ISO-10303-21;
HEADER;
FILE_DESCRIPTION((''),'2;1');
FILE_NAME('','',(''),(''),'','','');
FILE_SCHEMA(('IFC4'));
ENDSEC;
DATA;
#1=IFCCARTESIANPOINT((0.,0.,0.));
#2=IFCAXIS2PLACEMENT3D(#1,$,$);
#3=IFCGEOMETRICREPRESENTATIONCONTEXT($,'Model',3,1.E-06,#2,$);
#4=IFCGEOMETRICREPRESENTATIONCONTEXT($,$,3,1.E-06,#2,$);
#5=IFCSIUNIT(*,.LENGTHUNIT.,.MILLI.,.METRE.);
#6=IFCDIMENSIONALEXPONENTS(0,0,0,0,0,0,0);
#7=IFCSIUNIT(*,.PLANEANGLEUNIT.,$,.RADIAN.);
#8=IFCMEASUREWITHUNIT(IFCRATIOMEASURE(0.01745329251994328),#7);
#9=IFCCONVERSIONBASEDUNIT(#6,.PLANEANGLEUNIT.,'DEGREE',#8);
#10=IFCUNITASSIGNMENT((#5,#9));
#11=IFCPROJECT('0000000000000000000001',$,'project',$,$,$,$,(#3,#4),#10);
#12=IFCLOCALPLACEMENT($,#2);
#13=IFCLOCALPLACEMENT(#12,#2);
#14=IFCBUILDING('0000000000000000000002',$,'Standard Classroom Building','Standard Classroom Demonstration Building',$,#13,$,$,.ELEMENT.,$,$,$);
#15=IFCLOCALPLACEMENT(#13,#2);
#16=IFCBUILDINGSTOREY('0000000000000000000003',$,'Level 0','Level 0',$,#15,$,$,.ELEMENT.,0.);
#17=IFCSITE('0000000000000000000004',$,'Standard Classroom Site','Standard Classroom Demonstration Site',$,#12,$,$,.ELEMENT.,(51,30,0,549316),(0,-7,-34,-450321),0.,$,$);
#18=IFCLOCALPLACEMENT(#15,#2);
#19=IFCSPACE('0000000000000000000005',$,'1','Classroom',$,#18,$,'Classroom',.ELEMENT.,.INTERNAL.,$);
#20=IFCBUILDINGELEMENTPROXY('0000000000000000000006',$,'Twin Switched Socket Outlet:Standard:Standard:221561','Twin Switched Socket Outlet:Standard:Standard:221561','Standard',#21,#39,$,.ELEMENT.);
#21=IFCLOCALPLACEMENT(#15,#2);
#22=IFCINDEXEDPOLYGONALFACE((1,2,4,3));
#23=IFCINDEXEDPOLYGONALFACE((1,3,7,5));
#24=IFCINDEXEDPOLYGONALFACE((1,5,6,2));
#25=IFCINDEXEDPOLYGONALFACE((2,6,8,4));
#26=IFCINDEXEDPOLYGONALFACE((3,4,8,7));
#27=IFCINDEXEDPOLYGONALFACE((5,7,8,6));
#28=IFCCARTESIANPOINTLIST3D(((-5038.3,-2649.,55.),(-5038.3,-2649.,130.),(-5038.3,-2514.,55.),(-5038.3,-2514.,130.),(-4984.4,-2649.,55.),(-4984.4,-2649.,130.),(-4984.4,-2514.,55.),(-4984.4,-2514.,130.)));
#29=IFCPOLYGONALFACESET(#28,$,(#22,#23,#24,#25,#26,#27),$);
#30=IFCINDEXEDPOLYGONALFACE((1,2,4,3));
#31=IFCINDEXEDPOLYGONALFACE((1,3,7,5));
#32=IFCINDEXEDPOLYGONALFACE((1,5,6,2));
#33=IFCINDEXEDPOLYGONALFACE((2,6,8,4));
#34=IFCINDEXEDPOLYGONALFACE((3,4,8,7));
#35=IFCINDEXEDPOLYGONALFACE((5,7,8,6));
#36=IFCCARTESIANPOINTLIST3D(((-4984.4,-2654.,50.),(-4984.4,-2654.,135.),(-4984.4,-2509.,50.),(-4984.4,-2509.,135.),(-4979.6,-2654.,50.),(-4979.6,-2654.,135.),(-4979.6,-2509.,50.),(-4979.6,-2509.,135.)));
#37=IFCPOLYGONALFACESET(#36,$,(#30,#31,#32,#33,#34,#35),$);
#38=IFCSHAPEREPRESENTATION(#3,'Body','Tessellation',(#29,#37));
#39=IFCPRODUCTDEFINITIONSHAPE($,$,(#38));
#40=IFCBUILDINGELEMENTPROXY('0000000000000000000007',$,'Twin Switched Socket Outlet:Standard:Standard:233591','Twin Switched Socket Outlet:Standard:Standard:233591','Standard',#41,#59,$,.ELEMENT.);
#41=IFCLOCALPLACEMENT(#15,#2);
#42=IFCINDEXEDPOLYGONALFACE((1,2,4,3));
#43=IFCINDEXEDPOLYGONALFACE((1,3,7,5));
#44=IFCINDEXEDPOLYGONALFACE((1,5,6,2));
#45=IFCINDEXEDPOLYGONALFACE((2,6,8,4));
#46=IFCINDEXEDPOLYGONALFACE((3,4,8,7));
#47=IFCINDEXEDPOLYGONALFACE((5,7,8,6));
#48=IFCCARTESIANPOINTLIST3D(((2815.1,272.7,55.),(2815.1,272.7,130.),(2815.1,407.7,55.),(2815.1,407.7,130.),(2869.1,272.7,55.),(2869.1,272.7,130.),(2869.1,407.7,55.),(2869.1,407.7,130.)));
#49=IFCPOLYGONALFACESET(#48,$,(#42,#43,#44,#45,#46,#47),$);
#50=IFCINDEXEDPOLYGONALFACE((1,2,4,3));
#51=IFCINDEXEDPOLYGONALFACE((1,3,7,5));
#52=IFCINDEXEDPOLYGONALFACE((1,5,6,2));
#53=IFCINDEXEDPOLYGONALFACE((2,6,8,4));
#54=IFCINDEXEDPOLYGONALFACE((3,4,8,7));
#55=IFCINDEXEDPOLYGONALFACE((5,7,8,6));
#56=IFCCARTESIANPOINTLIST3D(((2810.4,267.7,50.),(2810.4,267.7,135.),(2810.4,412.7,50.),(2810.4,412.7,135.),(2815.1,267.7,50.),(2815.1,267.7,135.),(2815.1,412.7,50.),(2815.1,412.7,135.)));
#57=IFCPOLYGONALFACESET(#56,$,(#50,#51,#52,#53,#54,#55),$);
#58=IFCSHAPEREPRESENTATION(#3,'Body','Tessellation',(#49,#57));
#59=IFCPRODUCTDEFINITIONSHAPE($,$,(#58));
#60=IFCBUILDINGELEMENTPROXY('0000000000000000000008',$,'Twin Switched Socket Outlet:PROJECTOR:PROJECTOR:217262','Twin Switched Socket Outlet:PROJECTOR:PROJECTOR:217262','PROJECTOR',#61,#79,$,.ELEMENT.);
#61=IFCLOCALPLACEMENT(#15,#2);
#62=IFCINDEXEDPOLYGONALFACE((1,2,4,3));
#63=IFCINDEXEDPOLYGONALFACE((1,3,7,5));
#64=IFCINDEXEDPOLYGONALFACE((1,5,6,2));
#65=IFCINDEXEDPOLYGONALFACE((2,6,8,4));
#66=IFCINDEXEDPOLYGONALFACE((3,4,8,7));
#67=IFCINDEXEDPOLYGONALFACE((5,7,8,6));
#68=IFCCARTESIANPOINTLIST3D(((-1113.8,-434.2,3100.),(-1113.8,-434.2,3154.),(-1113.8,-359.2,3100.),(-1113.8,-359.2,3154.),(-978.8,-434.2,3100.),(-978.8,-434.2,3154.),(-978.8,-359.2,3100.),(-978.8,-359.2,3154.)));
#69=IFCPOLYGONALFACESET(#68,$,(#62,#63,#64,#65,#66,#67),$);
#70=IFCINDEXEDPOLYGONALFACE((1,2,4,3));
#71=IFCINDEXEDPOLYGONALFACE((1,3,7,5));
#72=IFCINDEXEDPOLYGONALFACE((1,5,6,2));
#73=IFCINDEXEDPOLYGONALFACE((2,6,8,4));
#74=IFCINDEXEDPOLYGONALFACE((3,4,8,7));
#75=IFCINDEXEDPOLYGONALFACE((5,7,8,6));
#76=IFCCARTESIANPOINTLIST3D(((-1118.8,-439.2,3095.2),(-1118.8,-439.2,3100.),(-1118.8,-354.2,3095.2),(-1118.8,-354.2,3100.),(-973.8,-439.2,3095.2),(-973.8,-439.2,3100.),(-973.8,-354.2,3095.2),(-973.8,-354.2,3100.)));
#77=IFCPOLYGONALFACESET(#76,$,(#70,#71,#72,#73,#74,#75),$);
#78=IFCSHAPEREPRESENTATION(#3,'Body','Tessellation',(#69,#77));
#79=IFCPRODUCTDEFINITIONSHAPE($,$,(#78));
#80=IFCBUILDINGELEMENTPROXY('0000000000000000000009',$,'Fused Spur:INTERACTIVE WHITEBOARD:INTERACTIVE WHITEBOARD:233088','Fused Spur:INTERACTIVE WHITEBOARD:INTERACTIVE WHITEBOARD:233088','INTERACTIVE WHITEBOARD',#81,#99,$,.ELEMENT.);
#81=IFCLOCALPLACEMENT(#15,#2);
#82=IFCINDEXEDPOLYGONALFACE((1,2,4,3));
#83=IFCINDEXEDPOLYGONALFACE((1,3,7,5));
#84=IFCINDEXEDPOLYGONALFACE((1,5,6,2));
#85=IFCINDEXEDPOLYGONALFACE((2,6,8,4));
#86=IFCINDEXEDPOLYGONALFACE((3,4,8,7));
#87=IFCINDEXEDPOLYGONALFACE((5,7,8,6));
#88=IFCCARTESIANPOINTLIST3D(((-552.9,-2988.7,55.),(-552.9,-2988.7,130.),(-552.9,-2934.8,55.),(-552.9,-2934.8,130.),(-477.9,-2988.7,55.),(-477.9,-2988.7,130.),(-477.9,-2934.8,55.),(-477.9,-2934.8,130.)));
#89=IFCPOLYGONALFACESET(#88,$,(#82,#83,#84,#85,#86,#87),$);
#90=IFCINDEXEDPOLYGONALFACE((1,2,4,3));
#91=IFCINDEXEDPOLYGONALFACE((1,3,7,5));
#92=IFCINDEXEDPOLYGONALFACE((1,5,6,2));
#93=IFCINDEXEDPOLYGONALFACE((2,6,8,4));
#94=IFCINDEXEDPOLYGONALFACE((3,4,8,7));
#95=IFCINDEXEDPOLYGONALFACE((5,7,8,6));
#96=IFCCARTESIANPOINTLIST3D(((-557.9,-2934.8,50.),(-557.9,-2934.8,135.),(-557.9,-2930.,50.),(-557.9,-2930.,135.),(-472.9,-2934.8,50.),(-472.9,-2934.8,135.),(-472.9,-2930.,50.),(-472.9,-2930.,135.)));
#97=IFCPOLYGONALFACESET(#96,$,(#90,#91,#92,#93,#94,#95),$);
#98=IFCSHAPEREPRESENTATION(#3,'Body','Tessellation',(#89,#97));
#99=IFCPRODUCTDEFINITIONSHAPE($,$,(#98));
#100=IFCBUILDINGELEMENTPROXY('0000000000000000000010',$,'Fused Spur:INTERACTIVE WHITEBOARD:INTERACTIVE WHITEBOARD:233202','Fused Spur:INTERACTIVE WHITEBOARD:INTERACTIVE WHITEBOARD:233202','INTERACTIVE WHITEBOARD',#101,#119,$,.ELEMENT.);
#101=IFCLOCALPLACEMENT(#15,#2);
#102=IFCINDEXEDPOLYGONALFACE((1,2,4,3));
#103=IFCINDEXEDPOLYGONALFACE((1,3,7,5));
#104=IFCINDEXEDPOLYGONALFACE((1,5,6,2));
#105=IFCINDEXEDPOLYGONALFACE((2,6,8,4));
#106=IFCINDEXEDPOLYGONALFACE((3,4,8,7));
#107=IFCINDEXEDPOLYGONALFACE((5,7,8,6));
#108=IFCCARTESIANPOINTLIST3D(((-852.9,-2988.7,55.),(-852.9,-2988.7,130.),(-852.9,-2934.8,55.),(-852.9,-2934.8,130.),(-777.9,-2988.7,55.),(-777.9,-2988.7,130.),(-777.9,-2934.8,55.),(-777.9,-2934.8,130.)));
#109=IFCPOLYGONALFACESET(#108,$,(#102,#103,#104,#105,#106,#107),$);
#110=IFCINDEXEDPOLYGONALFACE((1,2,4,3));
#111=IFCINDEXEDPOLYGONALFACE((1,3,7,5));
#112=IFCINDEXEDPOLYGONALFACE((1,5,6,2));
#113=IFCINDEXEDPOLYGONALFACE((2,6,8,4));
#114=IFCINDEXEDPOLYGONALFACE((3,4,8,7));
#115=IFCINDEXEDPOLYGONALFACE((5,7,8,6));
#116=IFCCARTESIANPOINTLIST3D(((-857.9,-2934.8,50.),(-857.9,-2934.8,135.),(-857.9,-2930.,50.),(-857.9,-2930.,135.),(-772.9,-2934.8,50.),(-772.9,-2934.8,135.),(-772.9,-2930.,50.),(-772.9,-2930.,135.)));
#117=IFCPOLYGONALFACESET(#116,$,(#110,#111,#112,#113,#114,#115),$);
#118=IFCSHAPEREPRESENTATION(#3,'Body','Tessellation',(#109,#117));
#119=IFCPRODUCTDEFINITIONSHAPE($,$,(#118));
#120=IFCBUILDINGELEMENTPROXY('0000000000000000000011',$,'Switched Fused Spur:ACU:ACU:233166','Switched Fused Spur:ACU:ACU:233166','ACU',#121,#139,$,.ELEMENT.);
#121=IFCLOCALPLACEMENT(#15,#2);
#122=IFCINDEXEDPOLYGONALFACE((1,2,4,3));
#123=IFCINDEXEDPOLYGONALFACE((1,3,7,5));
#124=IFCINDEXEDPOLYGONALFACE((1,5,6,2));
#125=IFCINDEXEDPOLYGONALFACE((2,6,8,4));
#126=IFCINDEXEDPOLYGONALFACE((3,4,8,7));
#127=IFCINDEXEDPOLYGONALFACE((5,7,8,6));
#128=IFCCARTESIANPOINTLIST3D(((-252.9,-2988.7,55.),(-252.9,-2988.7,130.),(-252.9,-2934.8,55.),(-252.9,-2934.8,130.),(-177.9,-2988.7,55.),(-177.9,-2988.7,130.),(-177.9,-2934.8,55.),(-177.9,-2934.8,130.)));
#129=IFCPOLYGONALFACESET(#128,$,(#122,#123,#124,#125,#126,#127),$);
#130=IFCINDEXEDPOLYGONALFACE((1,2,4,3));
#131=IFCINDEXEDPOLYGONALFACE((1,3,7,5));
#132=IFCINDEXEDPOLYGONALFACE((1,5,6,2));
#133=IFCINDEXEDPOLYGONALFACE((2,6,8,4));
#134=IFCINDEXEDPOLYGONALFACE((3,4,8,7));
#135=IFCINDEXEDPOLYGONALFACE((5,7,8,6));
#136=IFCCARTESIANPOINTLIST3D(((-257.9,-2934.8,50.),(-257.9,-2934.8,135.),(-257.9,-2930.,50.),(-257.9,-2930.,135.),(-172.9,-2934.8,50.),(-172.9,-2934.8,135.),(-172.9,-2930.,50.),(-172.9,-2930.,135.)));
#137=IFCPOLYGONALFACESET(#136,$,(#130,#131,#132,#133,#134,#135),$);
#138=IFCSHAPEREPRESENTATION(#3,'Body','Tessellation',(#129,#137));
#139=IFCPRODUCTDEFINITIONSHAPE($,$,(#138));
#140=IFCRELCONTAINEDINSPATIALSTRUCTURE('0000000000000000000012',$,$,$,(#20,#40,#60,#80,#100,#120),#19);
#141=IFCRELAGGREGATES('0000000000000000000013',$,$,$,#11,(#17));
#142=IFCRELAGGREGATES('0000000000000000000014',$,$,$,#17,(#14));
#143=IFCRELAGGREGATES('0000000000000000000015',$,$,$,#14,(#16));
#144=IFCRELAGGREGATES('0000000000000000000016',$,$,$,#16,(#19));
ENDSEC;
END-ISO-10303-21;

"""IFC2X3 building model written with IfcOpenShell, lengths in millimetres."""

from ifc_helpers import new_model, entity, si_unit, converted_unit, frame, origin, origin_2d_with_axis, place, context, project, spatial, rectangle, extrude, source, transform, mapped, element, save


model = new_model("IFC2X3")

# Units and contexts
model_context = context("Model", 3, precision=1e-06, world=origin())
context_of_model = context(None, 3, precision=1e-06, world=origin())
ifc_project = project(units=[si_unit("LENGTHUNIT", "METRE", prefix="MILLI"), converted_unit("PLANEANGLEUNIT", "DEGREE", entity("IfcRatioMeasure", 0.01745329251994328), si_unit("PLANEANGLEUNIT", "RADIAN"), dimensions=[0, 0, 0, 0, 0, 0, 0])], contexts=[model_context, context_of_model])

# Site, building, storey
site_placement = place(None, origin())
site = spatial("IfcSite", under=ifc_project, at=site_placement, Name="Standard Classroom Site", Description="Standard Classroom Demonstration Site", CompositionType="ELEMENT", RefLatitude=(51, 30, 0, 549316), RefLongitude=(0, -7, -34, -450321), RefElevation=0.0)
building_placement = place(site_placement, origin())
building = spatial("IfcBuilding", under=site, at=building_placement, Name="Standard Classroom Building", Description="Standard Classroom Demonstration Building", CompositionType="ELEMENT")
storey_placement = place(building_placement, origin())
storey = spatial("IfcBuildingStorey", under=building, at=storey_placement, Name="Level 0", Description="Level 0", CompositionType="ELEMENT", Elevation=0.0)

# Shared definitions
space_placement = place(storey_placement, origin())
space = spatial("IfcSpace", under=storey, at=space_placement, Name="1", Description="Classroom", LongName="Classroom", CompositionType="ELEMENT", InteriorOrExteriorSpace="INTERNAL")

# Building element proxies
shared_shape_1 = source(origin(), model_context, "Body", "SweptSolid", [
    extrude(rectangle(XDim=135.0, YDim=75.0, at=origin_2d_with_axis()), frame((0.0, 0.0, -54.0), z_axis=(0.0, 0.0, 1.0), x_axis=(-1.0, 0.0, 0.0)), (0.0, 0.0, 1.0), 54.0),
    extrude(rectangle(XDim=145.0, YDim=85.0, at=origin_2d_with_axis()), frame((0.0, 0.0, 0.0), z_axis=(0.0, 0.0, 1.0), x_axis=(-1.0, 0.0, 0.0)), (0.0, 0.0, 1.0), 4.8),
])
for number, where, z_axis, x_axis, name, description in (
    (1, (-4984.4, -2581.5, 92.5), (1.0, 0.0, 0.0), (0.0, 1.0, 0.0), "Twin Switched Socket Outlet:Standard:Standard:221561", "Twin Switched Socket Outlet:Standard:Standard:221561"),
    (2, (2815.1, 340.2, 92.5), (-1.0, 0.0, 0.0), (0.0, -1.0, 0.0), "Twin Switched Socket Outlet:Standard:Standard:233591", "Twin Switched Socket Outlet:Standard:Standard:233591"),
):
    element("IfcBuildingElementProxy", number, at=place(space_placement, frame(where, z_axis=z_axis, x_axis=x_axis)), inside=space, Name=name, Description=description, ObjectType="Standard", CompositionType="ELEMENT", context=model_context, shape_type="MappedRepresentation", body=[
        mapped(shared_shape_1, transform((0.0, 0.0, 0.0), scale=1.0)),
    ])
shared_shape_2 = source(origin(), model_context, "Body", "SweptSolid", [
    extrude(rectangle(XDim=135.0, YDim=75.0, at=origin_2d_with_axis()), frame((0.0, 0.0, -54.0), z_axis=(0.0, 0.0, 1.0), x_axis=(-1.0, 0.0, 0.0)), (0.0, 0.0, 1.0), 54.0),
    extrude(rectangle(XDim=145.0, YDim=85.0, at=origin_2d_with_axis()), frame((0.0, 0.0, 0.0), z_axis=(0.0, 0.0, 1.0), x_axis=(-1.0, 0.0, 0.0)), (0.0, 0.0, 1.0), 4.8),
])
proxy_1_placement = place(space_placement, frame((-1046.3, -396.7, 3100.0), z_axis=(0.0, 0.0, -1.0), x_axis=(1.0, 0.0, 0.0)))
element("IfcBuildingElementProxy", 3, at=proxy_1_placement, inside=space, Name="Twin Switched Socket Outlet:PROJECTOR:PROJECTOR:217262", Description="Twin Switched Socket Outlet:PROJECTOR:PROJECTOR:217262", ObjectType="PROJECTOR", CompositionType="ELEMENT", context=model_context, shape_type="MappedRepresentation", body=[
    mapped(shared_shape_2, transform((0.0, 0.0, 0.0), scale=1.0)),
])
shared_shape_3 = source(origin(), model_context, "Body", "SweptSolid", [
    extrude(rectangle(XDim=75.0, YDim=75.0, at=origin_2d_with_axis()), frame((0.0, 0.0, -54.0), z_axis=(0.0, 0.0, 1.0), x_axis=(-1.0, 0.0, 0.0)), (0.0, 0.0, 1.0), 54.0),
    extrude(rectangle(XDim=85.0, YDim=85.0, at=origin_2d_with_axis()), frame((0.0, 0.0, 0.0), z_axis=(0.0, 0.0, 1.0), x_axis=(-1.0, 0.0, 0.0)), (0.0, 0.0, 1.0), 4.8),
])
for number, where, z_axis, x_axis, name, description in (
    (4, (-515.4, -2934.8, 92.5), (0.0, 1.0, 0.0), (-1.0, 0.0, 0.0), "Fused Spur:INTERACTIVE WHITEBOARD:INTERACTIVE WHITEBOARD:233088", "Fused Spur:INTERACTIVE WHITEBOARD:INTERACTIVE WHITEBOARD:233088"),
    (5, (-815.4, -2934.8, 92.5), (0.0, 1.0, 0.0), (-1.0, 0.0, 0.0), "Fused Spur:INTERACTIVE WHITEBOARD:INTERACTIVE WHITEBOARD:233202", "Fused Spur:INTERACTIVE WHITEBOARD:INTERACTIVE WHITEBOARD:233202"),
):
    element("IfcBuildingElementProxy", number, at=place(space_placement, frame(where, z_axis=z_axis, x_axis=x_axis)), inside=space, Name=name, Description=description, ObjectType="INTERACTIVE WHITEBOARD", CompositionType="ELEMENT", context=model_context, shape_type="MappedRepresentation", body=[
        mapped(shared_shape_3, transform((0.0, 0.0, 0.0), scale=1.0)),
    ])
shared_shape_4 = source(origin(), model_context, "Body", "SweptSolid", [
    extrude(rectangle(XDim=75.0, YDim=75.0, at=origin_2d_with_axis()), frame((0.0, 0.0, -54.0), z_axis=(0.0, 0.0, 1.0), x_axis=(-1.0, 0.0, 0.0)), (0.0, 0.0, 1.0), 54.0),
    extrude(rectangle(XDim=85.0, YDim=85.0, at=origin_2d_with_axis()), frame((0.0, 0.0, 0.0), z_axis=(0.0, 0.0, 1.0), x_axis=(-1.0, 0.0, 0.0)), (0.0, 0.0, 1.0), 4.8),
])
proxy_2_placement = place(space_placement, frame((-215.4, -2934.8, 92.5), z_axis=(0.0, 1.0, 0.0), x_axis=(-1.0, 0.0, 0.0)))
element("IfcBuildingElementProxy", 6, at=proxy_2_placement, inside=space, Name="Switched Fused Spur:ACU:ACU:233166", Description="Switched Fused Spur:ACU:ACU:233166", ObjectType="ACU", CompositionType="ELEMENT", context=model_context, shape_type="MappedRepresentation", body=[
    mapped(shared_shape_4, transform((0.0, 0.0, 0.0), scale=1.0)),
])

save(model, "model.ifc")
